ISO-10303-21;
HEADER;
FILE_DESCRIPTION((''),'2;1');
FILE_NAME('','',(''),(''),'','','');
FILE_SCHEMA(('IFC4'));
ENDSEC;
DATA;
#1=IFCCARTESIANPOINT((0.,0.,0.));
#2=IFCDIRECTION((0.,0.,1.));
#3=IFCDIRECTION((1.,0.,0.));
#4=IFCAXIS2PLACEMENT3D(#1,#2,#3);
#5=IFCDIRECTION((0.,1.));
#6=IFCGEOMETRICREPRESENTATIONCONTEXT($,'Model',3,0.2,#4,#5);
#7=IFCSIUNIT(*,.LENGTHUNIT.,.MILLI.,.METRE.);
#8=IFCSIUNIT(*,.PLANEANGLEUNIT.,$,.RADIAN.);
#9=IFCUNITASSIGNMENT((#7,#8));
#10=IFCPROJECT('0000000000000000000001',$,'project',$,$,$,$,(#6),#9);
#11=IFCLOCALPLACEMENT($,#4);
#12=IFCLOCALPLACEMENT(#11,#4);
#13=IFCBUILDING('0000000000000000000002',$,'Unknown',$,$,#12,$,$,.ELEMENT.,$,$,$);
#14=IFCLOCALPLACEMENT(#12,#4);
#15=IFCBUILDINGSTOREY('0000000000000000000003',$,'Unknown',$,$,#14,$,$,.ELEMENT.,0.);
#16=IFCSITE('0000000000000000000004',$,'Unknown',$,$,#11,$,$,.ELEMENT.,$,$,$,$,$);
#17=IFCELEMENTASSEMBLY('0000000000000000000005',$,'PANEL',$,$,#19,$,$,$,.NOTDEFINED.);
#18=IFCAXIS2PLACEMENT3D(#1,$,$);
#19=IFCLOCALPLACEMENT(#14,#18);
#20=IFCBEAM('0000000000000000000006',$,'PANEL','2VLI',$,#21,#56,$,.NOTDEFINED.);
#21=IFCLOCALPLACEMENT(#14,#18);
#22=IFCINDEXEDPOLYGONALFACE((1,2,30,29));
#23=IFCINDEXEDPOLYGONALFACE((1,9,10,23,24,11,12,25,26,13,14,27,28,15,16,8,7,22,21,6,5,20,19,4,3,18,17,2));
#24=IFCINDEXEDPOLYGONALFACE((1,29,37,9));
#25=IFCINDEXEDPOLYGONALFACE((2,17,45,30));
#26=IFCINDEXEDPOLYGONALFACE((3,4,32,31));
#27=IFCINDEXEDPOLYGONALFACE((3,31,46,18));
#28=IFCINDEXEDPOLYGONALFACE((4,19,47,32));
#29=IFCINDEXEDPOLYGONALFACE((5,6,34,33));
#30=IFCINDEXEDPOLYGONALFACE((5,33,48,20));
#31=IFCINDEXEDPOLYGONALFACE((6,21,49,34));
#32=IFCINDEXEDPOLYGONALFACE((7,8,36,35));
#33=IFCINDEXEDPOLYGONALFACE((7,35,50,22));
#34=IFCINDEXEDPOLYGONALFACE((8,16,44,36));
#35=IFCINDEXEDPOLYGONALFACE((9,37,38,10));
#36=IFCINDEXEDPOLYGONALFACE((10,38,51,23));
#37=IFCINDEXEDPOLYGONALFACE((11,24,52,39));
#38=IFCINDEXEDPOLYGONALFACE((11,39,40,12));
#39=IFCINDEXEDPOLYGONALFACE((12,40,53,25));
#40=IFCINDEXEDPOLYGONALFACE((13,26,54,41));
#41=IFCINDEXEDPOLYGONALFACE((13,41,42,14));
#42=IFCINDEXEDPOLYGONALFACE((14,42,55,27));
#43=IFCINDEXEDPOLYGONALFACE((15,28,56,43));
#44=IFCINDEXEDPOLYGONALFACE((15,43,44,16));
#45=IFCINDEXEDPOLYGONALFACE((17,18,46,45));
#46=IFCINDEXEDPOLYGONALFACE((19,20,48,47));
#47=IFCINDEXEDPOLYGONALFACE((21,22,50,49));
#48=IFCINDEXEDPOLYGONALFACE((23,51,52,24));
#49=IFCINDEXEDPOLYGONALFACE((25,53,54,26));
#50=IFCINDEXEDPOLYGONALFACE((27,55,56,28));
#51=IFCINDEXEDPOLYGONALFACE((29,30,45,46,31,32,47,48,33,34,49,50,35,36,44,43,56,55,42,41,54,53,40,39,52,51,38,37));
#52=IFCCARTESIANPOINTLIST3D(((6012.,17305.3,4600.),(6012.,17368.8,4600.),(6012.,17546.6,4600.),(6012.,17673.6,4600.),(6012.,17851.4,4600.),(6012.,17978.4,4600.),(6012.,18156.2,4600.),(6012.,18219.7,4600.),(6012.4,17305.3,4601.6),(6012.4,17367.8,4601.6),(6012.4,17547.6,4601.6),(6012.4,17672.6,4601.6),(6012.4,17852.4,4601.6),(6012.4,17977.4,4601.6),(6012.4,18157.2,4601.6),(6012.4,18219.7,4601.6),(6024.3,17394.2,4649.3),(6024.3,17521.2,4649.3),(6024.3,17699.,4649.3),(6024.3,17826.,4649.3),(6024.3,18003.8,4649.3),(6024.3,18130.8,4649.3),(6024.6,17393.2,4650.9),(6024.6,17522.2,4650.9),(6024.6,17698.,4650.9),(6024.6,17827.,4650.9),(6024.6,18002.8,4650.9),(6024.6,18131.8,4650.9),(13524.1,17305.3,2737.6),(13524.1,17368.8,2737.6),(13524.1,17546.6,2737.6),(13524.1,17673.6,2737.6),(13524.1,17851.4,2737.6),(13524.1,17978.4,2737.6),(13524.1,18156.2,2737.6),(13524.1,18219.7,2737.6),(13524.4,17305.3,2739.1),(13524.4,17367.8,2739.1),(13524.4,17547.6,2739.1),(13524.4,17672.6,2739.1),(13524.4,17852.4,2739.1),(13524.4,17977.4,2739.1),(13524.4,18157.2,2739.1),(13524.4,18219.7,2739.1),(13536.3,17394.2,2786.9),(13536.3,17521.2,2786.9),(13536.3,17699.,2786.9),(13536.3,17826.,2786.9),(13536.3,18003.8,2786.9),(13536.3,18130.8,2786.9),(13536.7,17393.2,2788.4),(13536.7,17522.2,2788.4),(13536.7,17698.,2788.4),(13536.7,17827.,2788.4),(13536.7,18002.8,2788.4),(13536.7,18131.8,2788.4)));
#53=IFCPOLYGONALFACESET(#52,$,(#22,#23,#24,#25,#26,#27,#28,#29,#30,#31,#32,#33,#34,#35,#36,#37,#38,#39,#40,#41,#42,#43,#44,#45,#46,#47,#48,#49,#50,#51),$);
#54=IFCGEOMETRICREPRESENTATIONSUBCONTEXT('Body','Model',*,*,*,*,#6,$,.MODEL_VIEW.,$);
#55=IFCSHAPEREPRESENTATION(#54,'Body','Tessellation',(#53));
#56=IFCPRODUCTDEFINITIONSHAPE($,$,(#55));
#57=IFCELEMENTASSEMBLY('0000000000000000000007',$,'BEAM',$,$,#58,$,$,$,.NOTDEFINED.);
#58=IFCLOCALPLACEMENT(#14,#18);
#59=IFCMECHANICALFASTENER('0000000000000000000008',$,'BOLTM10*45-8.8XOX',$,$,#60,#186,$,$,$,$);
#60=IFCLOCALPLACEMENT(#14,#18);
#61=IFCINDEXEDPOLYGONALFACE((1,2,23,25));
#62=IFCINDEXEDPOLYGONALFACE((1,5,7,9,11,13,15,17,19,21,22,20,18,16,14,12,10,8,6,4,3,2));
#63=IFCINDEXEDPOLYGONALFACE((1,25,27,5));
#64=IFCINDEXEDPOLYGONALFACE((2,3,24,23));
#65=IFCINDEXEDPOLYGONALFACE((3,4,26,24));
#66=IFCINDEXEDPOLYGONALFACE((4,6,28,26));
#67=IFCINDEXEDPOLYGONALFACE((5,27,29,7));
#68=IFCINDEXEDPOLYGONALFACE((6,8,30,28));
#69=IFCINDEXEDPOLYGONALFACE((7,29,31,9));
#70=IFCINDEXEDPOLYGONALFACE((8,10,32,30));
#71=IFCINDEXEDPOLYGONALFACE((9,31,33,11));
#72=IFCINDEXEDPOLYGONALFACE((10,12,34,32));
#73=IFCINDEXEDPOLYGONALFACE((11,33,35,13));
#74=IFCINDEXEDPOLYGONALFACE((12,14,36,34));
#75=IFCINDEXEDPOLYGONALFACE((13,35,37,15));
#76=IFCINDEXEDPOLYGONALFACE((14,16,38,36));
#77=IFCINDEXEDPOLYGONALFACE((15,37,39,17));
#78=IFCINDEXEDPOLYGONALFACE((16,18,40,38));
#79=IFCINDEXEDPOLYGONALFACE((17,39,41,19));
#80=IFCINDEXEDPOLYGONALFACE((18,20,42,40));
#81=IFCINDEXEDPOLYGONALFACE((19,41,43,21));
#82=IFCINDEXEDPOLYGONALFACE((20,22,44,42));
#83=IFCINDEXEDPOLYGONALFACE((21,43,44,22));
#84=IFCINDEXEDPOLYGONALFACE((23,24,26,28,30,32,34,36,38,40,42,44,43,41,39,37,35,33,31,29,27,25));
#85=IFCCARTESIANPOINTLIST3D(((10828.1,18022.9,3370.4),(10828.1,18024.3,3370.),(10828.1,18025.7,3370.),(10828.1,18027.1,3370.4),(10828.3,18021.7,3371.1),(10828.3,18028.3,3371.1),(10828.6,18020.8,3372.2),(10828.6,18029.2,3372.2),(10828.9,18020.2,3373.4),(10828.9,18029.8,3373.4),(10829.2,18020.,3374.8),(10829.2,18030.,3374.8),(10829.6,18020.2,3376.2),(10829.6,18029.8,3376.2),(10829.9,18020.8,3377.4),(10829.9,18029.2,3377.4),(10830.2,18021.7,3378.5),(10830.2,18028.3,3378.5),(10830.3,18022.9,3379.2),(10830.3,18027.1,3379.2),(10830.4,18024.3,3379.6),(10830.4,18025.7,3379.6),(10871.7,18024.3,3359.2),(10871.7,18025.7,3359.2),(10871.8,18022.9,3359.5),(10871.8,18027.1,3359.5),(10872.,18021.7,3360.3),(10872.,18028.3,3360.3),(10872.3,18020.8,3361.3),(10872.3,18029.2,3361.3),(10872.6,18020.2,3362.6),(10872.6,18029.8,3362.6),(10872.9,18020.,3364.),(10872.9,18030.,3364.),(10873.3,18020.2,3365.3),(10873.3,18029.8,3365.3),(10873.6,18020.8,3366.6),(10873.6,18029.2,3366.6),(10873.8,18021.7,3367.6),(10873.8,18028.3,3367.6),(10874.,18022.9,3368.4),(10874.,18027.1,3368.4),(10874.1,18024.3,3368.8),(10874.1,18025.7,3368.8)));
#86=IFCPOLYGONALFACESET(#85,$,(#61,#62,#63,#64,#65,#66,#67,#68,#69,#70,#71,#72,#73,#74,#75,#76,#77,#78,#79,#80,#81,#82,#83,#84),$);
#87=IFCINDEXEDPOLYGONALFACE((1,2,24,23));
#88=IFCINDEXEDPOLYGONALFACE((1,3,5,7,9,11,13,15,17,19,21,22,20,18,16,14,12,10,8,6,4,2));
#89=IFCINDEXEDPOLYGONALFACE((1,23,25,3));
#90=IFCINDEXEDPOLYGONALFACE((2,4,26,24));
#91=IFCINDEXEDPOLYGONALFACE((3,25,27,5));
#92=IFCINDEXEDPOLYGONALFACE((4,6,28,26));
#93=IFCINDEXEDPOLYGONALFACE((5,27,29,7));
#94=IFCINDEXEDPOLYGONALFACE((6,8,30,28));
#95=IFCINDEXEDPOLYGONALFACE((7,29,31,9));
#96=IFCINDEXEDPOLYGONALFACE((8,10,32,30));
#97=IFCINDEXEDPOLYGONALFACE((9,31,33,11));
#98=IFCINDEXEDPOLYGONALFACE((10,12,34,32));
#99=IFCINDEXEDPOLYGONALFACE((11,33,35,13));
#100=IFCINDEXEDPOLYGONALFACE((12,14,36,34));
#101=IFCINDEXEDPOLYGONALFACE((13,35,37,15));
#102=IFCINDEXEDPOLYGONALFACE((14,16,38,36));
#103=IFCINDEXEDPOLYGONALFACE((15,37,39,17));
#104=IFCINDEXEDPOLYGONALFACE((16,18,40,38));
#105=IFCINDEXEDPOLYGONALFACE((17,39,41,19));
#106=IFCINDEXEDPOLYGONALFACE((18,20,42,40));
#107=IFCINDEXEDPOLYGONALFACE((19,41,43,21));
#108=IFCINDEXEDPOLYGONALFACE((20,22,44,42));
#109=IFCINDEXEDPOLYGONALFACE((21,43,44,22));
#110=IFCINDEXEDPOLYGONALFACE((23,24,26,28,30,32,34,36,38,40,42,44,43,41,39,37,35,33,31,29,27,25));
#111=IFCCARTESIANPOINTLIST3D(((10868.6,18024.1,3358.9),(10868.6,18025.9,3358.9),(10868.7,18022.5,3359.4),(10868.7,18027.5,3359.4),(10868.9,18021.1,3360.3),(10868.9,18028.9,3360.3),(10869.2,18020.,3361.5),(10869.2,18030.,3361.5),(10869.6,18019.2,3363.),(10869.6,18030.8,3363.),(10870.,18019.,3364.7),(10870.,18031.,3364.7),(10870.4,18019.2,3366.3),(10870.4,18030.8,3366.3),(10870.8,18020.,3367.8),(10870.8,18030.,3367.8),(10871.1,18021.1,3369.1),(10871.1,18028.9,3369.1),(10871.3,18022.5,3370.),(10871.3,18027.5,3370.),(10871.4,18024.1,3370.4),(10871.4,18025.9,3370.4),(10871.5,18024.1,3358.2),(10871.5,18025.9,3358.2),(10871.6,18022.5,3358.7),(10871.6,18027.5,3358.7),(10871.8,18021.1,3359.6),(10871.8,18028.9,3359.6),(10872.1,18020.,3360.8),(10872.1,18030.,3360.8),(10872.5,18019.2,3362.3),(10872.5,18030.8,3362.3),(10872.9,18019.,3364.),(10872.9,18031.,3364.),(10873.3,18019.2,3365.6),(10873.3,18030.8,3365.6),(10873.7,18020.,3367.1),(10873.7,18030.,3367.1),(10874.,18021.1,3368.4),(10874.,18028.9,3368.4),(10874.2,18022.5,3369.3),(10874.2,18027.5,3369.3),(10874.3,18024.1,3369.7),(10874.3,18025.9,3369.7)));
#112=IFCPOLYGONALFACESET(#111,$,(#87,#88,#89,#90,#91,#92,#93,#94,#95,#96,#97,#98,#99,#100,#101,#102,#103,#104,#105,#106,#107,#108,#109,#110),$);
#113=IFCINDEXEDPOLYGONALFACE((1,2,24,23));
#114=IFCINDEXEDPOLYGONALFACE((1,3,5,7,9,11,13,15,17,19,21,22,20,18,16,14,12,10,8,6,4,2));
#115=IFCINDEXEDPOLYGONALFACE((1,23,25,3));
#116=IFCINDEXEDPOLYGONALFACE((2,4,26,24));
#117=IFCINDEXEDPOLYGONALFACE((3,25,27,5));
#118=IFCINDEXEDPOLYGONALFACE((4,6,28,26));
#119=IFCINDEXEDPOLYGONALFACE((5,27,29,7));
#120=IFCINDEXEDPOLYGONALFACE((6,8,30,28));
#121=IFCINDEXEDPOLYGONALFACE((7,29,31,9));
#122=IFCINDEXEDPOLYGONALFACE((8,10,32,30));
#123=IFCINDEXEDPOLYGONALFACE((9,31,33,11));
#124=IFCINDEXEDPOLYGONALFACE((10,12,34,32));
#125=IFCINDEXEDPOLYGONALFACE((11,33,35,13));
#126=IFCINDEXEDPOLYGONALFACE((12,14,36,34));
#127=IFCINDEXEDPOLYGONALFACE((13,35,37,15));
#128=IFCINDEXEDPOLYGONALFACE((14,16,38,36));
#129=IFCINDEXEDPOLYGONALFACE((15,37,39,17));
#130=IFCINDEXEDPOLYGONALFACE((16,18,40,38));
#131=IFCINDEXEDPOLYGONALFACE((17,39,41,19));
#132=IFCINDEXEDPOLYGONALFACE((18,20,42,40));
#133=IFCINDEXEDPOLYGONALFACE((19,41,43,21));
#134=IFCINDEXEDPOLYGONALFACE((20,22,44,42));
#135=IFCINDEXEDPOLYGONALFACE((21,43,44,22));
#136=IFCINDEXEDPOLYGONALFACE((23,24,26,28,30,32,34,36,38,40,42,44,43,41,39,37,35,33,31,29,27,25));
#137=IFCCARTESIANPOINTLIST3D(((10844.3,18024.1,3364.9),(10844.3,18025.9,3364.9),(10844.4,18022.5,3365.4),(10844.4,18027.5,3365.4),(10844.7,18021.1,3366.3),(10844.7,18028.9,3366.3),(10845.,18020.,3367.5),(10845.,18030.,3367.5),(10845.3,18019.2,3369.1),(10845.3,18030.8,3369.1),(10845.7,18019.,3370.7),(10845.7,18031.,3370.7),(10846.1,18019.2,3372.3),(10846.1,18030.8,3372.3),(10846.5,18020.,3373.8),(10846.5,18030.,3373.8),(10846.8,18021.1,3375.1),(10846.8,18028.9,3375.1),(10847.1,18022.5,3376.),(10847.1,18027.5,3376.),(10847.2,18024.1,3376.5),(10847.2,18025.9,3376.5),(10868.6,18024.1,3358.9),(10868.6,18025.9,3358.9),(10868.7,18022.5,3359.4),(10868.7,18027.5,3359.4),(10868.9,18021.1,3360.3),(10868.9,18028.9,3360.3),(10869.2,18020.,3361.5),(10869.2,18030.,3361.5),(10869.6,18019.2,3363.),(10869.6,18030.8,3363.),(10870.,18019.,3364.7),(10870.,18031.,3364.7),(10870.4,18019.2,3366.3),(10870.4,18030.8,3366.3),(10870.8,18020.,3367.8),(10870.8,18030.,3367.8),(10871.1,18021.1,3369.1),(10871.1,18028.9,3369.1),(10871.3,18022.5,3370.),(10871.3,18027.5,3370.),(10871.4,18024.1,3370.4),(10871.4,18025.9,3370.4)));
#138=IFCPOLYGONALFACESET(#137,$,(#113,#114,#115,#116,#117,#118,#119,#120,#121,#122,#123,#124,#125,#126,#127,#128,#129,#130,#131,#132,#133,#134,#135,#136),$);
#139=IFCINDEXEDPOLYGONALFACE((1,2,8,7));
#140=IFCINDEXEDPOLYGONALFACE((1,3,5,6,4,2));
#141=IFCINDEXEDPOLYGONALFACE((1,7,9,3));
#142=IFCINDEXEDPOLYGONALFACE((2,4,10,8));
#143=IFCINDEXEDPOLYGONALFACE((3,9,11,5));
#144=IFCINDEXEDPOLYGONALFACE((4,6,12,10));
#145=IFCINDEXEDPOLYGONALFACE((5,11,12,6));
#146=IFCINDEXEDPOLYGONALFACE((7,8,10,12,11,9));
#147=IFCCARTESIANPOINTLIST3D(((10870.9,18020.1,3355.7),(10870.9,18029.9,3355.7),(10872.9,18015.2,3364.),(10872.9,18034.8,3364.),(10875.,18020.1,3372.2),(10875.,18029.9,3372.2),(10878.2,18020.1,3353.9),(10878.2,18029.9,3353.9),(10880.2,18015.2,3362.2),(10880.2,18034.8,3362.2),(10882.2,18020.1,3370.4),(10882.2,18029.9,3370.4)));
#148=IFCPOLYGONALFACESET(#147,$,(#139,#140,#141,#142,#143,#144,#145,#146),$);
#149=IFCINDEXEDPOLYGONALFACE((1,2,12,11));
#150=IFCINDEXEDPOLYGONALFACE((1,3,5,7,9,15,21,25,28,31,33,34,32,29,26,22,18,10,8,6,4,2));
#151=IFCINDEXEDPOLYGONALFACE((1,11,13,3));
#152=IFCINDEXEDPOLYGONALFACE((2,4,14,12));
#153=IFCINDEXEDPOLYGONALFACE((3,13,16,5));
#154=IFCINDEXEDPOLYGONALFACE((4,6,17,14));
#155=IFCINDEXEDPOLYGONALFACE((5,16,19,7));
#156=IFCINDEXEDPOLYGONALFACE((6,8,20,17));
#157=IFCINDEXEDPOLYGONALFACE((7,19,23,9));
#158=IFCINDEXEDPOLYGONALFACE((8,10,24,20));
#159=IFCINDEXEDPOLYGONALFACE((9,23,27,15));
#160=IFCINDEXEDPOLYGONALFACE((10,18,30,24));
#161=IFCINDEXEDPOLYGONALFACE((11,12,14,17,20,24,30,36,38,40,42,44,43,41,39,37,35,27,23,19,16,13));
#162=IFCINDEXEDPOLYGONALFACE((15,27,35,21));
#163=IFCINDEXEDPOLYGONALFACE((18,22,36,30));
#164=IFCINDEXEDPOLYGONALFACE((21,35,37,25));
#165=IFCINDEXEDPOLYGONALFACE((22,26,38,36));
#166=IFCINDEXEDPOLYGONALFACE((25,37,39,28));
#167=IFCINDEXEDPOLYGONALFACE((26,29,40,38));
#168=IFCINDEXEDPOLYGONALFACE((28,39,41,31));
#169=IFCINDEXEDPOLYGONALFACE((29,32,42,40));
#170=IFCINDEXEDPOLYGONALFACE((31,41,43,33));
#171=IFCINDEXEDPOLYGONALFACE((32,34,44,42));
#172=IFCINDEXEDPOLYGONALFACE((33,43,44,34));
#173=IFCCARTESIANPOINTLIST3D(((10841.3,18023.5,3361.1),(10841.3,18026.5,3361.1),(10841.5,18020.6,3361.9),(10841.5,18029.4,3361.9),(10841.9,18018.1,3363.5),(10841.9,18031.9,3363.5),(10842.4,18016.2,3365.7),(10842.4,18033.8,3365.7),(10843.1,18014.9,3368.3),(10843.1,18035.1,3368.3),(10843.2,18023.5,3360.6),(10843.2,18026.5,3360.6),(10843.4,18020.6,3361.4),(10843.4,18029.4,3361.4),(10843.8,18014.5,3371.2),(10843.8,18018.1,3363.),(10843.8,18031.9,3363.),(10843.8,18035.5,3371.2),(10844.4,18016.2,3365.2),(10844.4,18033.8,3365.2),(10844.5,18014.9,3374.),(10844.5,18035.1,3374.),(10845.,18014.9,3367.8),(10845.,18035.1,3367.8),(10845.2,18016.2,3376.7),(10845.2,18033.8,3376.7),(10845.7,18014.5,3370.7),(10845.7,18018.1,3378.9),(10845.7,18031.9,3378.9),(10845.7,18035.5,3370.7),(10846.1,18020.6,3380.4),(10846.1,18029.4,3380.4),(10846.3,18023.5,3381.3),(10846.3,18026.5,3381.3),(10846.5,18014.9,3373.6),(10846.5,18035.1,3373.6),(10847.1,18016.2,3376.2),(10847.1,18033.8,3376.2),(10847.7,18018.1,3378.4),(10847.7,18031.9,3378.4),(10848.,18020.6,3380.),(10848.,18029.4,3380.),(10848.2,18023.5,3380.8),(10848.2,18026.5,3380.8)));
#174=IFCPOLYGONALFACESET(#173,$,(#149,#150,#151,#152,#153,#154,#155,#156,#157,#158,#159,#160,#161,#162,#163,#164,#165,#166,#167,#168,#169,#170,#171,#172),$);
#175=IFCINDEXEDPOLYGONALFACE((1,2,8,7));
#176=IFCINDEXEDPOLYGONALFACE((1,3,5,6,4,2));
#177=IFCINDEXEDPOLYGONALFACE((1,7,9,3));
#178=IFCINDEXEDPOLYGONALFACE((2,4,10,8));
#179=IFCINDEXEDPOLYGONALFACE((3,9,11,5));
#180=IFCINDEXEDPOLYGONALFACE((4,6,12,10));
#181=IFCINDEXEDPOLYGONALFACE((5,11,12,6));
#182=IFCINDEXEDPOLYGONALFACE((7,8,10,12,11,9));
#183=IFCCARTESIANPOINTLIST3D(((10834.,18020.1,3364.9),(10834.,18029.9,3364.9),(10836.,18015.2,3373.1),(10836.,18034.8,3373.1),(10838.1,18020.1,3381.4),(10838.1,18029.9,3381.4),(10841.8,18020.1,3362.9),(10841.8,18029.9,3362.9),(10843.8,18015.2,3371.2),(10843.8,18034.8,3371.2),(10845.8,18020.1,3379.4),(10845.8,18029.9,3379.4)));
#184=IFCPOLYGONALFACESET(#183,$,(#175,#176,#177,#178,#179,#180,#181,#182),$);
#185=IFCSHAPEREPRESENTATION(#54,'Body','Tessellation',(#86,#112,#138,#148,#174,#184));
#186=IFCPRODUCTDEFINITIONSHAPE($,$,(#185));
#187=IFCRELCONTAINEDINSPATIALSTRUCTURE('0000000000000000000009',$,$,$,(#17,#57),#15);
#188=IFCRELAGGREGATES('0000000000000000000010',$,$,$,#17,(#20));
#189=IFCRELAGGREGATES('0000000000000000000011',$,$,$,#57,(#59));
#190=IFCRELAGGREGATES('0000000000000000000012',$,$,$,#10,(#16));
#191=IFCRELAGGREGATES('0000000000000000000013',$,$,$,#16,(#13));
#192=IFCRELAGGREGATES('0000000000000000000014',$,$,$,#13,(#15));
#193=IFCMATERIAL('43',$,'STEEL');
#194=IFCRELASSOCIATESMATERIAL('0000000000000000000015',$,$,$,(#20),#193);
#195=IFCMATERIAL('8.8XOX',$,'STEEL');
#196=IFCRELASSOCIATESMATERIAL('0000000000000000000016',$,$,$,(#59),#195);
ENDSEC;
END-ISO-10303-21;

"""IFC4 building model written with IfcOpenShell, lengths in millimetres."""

from ifc_helpers import new_model, si_unit, direction, frame, origin_with_axes, place, context, subcontext, project, spatial, line, arc, indexed_curve, outline, extrude, source, transform, mapped, material, element, aggregate, save


model = new_model("IFC4")

# Units and contexts
model_context = context("Model", 3, precision=0.2, world=origin_with_axes(), true_north=direction((0.0, 1.0)))
body_context = subcontext(model_context, "Body", "Model", "MODEL_VIEW")
ifc_project = project(units=[si_unit("LENGTHUNIT", "METRE", prefix="MILLI"), si_unit("PLANEANGLEUNIT", "RADIAN")], contexts=[model_context])

# Site, building, storey
site_placement = place(None, origin_with_axes())
site = spatial("IfcSite", under=ifc_project, at=site_placement, Name="Unknown", CompositionType="ELEMENT")
building_placement = place(site_placement, origin_with_axes())
building = spatial("IfcBuilding", under=site, at=building_placement, Name="Unknown", CompositionType="ELEMENT")
storey_placement = place(building_placement, origin_with_axes())
storey = spatial("IfcBuildingStorey", under=building, at=storey_placement, Name="Unknown", CompositionType="ELEMENT", Elevation=0.0)

# Element assembly, beam
ifc_material_1 = material(Name="43", Category="STEEL")
assembly_1_placement = place(storey_placement, frame((6018.3, 17762.5, 4625.5), z_axis=(0.0, -1.0, 0.0), x_axis=(0.970613, 0.0, -0.240648)))
assembly_1 = element("IfcElementAssembly", 1, at=assembly_1_placement, inside=storey, Name="PANEL", PredefinedType="NOTDEFINED")
beam_1_placement = place(assembly_1_placement, origin_with_axes())
beam_1 = element("IfcBeam", 2, at=beam_1_placement, material=ifc_material_1, Name="PANEL", Description="2VLI", PredefinedType="NOTDEFINED", context=body_context, shape_type="SolidModel", body=[
    extrude(outline(indexed_curve([(457.2, -26.2), (457.2, -24.6), (394.7, -24.6), (369.3, 26.2), (240.3, 26.2), (214.9, -24.6), (89.9, -24.6), (64.5, 26.2), (-64.5, 26.2), (-89.9, -24.6), (-214.9, -24.6), (-240.3, 26.2), (-369.3, 26.2), (-394.7, -24.6), (-457.2, -24.6), (-457.2, -26.2), (-393.7, -26.2), (-368.3, 24.6), (-241.3, 24.6), (-215.9, -26.2), (-88.9, -26.2), (-63.5, 24.6), (63.5, 24.6), (88.9, -26.2), (215.9, -26.2), (241.3, 24.6), (368.3, 24.6), (393.7, -26.2)], segments=[line(1, 2, 3, 4, 5, 6, 7, 8, 9, 10, 11, 12, 13, 14, 15, 16, 17, 18, 19, 20, 21, 22, 23, 24, 25, 26, 27, 28, 1)])), frame((0.0, 0.0, 0.0), z_axis=(-1.0, 0.0, 0.0), x_axis=(0.0, 0.0, 1.0)), (0.0, 0.0, -1.0), 7739.5),
])
aggregate(assembly_1, [beam_1])

# Shared definitions
ifc_material_2 = material(Name="8.8XOX", Category="STEEL")

# Element assembly, mechanical fastener
assembly_2_placement = place(storey_placement, frame((10859.1, 18000.0, 3372.5), z_axis=(0.970613, 0.0, -0.240648), x_axis=(0.0, 1.0, 0.0)))
assembly_2 = element("IfcElementAssembly", 3, at=assembly_2_placement, inside=storey, Name="BEAM", PredefinedType="NOTDEFINED")
shared_shape_1 = source(origin_with_axes(), body_context, "Body", "SweptSolid", [
    extrude(outline(indexed_curve([(5.0, 0.0), (0.0, 5.0), (-5.0, 0.0), (0.0, -5.0)], segments=[arc(1, 2, 3), arc(3, 4, 1)])), frame((0.0, 0.0, 3.8), z_axis=(0.0, 0.0, -1.0), x_axis=(0.0, 1.0, 0.0)), (0.0, 0.0, 1.0), 45.0),
    extrude(outline(indexed_curve([(6.0, 0.0), (0.0, 6.0), (-6.0, 0.0), (0.0, -6.0)], segments=[arc(1, 2, 3), arc(3, 4, 1)])), frame((0.0, 0.0, 3.8), z_axis=(0.0, 0.0, -1.0), x_axis=(0.0, 1.0, 0.0)), (0.0, 0.0, 1.0), 3.0),
    extrude(outline(indexed_curve([(6.0, 0.0), (0.0, 6.0), (-6.0, 0.0), (0.0, -6.0)], segments=[arc(1, 2, 3), arc(3, 4, 1)])), frame((0.0, 0.0, 0.8), z_axis=(0.0, 0.0, -1.0), x_axis=(0.0, 1.0, 0.0)), (0.0, 0.0, 1.0), 25.0),
    extrude(outline(indexed_curve([(9.8, 0.0), (4.9, 8.5), (-4.9, 8.5), (-9.8, 0.0), (-4.9, -8.5), (4.9, -8.5)], segments=[line(1, 2, 3, 4, 5, 6, 1)])), frame((0.0, 0.0, 11.2), z_axis=(0.0, 0.0, -1.0), x_axis=(0.0, 1.0, 0.0)), (0.0, 0.0, 1.0), 7.5),
    extrude(outline(indexed_curve([(10.5, 0.0), (0.0, 10.5), (-10.5, 0.0), (0.0, -10.5)], segments=[arc(1, 2, 3), arc(3, 4, 1)])), frame((0.0, 0.0, -24.2), z_axis=(0.0, 0.0, -1.0), x_axis=(0.0, 1.0, 0.0)), (0.0, 0.0, 1.0), 2.0),
    extrude(outline(indexed_curve([(9.8, 0.0), (4.9, 8.5), (-4.9, 8.5), (-9.8, 0.0), (-4.9, -8.5), (4.9, -8.5)], segments=[line(1, 2, 3, 4, 5, 6, 1)])), frame((0.0, 0.0, -26.2), z_axis=(0.0, 0.0, -1.0), x_axis=(0.0, 1.0, 0.0)), (0.0, 0.0, 1.0), 8.0),
])
mechanical_fastener_1_placement = place(assembly_2_placement, frame((25.0, -5.0, 11.8), z_axis=(0.0, 0.0, 1.0), x_axis=(0.0, 1.0, 0.0)))
mechanical_fastener_1 = element("IfcMechanicalFastener", 4, at=mechanical_fastener_1_placement, material=ifc_material_2, Name="BOLTM10*45-8.8XOX", context=body_context, shape_type="MappedRepresentation", body=[
    mapped(shared_shape_1, transform((0.0, 0.0, 0.0))),
])
aggregate(assembly_2, [mechanical_fastener_1])

save(model, "model.ifc")
